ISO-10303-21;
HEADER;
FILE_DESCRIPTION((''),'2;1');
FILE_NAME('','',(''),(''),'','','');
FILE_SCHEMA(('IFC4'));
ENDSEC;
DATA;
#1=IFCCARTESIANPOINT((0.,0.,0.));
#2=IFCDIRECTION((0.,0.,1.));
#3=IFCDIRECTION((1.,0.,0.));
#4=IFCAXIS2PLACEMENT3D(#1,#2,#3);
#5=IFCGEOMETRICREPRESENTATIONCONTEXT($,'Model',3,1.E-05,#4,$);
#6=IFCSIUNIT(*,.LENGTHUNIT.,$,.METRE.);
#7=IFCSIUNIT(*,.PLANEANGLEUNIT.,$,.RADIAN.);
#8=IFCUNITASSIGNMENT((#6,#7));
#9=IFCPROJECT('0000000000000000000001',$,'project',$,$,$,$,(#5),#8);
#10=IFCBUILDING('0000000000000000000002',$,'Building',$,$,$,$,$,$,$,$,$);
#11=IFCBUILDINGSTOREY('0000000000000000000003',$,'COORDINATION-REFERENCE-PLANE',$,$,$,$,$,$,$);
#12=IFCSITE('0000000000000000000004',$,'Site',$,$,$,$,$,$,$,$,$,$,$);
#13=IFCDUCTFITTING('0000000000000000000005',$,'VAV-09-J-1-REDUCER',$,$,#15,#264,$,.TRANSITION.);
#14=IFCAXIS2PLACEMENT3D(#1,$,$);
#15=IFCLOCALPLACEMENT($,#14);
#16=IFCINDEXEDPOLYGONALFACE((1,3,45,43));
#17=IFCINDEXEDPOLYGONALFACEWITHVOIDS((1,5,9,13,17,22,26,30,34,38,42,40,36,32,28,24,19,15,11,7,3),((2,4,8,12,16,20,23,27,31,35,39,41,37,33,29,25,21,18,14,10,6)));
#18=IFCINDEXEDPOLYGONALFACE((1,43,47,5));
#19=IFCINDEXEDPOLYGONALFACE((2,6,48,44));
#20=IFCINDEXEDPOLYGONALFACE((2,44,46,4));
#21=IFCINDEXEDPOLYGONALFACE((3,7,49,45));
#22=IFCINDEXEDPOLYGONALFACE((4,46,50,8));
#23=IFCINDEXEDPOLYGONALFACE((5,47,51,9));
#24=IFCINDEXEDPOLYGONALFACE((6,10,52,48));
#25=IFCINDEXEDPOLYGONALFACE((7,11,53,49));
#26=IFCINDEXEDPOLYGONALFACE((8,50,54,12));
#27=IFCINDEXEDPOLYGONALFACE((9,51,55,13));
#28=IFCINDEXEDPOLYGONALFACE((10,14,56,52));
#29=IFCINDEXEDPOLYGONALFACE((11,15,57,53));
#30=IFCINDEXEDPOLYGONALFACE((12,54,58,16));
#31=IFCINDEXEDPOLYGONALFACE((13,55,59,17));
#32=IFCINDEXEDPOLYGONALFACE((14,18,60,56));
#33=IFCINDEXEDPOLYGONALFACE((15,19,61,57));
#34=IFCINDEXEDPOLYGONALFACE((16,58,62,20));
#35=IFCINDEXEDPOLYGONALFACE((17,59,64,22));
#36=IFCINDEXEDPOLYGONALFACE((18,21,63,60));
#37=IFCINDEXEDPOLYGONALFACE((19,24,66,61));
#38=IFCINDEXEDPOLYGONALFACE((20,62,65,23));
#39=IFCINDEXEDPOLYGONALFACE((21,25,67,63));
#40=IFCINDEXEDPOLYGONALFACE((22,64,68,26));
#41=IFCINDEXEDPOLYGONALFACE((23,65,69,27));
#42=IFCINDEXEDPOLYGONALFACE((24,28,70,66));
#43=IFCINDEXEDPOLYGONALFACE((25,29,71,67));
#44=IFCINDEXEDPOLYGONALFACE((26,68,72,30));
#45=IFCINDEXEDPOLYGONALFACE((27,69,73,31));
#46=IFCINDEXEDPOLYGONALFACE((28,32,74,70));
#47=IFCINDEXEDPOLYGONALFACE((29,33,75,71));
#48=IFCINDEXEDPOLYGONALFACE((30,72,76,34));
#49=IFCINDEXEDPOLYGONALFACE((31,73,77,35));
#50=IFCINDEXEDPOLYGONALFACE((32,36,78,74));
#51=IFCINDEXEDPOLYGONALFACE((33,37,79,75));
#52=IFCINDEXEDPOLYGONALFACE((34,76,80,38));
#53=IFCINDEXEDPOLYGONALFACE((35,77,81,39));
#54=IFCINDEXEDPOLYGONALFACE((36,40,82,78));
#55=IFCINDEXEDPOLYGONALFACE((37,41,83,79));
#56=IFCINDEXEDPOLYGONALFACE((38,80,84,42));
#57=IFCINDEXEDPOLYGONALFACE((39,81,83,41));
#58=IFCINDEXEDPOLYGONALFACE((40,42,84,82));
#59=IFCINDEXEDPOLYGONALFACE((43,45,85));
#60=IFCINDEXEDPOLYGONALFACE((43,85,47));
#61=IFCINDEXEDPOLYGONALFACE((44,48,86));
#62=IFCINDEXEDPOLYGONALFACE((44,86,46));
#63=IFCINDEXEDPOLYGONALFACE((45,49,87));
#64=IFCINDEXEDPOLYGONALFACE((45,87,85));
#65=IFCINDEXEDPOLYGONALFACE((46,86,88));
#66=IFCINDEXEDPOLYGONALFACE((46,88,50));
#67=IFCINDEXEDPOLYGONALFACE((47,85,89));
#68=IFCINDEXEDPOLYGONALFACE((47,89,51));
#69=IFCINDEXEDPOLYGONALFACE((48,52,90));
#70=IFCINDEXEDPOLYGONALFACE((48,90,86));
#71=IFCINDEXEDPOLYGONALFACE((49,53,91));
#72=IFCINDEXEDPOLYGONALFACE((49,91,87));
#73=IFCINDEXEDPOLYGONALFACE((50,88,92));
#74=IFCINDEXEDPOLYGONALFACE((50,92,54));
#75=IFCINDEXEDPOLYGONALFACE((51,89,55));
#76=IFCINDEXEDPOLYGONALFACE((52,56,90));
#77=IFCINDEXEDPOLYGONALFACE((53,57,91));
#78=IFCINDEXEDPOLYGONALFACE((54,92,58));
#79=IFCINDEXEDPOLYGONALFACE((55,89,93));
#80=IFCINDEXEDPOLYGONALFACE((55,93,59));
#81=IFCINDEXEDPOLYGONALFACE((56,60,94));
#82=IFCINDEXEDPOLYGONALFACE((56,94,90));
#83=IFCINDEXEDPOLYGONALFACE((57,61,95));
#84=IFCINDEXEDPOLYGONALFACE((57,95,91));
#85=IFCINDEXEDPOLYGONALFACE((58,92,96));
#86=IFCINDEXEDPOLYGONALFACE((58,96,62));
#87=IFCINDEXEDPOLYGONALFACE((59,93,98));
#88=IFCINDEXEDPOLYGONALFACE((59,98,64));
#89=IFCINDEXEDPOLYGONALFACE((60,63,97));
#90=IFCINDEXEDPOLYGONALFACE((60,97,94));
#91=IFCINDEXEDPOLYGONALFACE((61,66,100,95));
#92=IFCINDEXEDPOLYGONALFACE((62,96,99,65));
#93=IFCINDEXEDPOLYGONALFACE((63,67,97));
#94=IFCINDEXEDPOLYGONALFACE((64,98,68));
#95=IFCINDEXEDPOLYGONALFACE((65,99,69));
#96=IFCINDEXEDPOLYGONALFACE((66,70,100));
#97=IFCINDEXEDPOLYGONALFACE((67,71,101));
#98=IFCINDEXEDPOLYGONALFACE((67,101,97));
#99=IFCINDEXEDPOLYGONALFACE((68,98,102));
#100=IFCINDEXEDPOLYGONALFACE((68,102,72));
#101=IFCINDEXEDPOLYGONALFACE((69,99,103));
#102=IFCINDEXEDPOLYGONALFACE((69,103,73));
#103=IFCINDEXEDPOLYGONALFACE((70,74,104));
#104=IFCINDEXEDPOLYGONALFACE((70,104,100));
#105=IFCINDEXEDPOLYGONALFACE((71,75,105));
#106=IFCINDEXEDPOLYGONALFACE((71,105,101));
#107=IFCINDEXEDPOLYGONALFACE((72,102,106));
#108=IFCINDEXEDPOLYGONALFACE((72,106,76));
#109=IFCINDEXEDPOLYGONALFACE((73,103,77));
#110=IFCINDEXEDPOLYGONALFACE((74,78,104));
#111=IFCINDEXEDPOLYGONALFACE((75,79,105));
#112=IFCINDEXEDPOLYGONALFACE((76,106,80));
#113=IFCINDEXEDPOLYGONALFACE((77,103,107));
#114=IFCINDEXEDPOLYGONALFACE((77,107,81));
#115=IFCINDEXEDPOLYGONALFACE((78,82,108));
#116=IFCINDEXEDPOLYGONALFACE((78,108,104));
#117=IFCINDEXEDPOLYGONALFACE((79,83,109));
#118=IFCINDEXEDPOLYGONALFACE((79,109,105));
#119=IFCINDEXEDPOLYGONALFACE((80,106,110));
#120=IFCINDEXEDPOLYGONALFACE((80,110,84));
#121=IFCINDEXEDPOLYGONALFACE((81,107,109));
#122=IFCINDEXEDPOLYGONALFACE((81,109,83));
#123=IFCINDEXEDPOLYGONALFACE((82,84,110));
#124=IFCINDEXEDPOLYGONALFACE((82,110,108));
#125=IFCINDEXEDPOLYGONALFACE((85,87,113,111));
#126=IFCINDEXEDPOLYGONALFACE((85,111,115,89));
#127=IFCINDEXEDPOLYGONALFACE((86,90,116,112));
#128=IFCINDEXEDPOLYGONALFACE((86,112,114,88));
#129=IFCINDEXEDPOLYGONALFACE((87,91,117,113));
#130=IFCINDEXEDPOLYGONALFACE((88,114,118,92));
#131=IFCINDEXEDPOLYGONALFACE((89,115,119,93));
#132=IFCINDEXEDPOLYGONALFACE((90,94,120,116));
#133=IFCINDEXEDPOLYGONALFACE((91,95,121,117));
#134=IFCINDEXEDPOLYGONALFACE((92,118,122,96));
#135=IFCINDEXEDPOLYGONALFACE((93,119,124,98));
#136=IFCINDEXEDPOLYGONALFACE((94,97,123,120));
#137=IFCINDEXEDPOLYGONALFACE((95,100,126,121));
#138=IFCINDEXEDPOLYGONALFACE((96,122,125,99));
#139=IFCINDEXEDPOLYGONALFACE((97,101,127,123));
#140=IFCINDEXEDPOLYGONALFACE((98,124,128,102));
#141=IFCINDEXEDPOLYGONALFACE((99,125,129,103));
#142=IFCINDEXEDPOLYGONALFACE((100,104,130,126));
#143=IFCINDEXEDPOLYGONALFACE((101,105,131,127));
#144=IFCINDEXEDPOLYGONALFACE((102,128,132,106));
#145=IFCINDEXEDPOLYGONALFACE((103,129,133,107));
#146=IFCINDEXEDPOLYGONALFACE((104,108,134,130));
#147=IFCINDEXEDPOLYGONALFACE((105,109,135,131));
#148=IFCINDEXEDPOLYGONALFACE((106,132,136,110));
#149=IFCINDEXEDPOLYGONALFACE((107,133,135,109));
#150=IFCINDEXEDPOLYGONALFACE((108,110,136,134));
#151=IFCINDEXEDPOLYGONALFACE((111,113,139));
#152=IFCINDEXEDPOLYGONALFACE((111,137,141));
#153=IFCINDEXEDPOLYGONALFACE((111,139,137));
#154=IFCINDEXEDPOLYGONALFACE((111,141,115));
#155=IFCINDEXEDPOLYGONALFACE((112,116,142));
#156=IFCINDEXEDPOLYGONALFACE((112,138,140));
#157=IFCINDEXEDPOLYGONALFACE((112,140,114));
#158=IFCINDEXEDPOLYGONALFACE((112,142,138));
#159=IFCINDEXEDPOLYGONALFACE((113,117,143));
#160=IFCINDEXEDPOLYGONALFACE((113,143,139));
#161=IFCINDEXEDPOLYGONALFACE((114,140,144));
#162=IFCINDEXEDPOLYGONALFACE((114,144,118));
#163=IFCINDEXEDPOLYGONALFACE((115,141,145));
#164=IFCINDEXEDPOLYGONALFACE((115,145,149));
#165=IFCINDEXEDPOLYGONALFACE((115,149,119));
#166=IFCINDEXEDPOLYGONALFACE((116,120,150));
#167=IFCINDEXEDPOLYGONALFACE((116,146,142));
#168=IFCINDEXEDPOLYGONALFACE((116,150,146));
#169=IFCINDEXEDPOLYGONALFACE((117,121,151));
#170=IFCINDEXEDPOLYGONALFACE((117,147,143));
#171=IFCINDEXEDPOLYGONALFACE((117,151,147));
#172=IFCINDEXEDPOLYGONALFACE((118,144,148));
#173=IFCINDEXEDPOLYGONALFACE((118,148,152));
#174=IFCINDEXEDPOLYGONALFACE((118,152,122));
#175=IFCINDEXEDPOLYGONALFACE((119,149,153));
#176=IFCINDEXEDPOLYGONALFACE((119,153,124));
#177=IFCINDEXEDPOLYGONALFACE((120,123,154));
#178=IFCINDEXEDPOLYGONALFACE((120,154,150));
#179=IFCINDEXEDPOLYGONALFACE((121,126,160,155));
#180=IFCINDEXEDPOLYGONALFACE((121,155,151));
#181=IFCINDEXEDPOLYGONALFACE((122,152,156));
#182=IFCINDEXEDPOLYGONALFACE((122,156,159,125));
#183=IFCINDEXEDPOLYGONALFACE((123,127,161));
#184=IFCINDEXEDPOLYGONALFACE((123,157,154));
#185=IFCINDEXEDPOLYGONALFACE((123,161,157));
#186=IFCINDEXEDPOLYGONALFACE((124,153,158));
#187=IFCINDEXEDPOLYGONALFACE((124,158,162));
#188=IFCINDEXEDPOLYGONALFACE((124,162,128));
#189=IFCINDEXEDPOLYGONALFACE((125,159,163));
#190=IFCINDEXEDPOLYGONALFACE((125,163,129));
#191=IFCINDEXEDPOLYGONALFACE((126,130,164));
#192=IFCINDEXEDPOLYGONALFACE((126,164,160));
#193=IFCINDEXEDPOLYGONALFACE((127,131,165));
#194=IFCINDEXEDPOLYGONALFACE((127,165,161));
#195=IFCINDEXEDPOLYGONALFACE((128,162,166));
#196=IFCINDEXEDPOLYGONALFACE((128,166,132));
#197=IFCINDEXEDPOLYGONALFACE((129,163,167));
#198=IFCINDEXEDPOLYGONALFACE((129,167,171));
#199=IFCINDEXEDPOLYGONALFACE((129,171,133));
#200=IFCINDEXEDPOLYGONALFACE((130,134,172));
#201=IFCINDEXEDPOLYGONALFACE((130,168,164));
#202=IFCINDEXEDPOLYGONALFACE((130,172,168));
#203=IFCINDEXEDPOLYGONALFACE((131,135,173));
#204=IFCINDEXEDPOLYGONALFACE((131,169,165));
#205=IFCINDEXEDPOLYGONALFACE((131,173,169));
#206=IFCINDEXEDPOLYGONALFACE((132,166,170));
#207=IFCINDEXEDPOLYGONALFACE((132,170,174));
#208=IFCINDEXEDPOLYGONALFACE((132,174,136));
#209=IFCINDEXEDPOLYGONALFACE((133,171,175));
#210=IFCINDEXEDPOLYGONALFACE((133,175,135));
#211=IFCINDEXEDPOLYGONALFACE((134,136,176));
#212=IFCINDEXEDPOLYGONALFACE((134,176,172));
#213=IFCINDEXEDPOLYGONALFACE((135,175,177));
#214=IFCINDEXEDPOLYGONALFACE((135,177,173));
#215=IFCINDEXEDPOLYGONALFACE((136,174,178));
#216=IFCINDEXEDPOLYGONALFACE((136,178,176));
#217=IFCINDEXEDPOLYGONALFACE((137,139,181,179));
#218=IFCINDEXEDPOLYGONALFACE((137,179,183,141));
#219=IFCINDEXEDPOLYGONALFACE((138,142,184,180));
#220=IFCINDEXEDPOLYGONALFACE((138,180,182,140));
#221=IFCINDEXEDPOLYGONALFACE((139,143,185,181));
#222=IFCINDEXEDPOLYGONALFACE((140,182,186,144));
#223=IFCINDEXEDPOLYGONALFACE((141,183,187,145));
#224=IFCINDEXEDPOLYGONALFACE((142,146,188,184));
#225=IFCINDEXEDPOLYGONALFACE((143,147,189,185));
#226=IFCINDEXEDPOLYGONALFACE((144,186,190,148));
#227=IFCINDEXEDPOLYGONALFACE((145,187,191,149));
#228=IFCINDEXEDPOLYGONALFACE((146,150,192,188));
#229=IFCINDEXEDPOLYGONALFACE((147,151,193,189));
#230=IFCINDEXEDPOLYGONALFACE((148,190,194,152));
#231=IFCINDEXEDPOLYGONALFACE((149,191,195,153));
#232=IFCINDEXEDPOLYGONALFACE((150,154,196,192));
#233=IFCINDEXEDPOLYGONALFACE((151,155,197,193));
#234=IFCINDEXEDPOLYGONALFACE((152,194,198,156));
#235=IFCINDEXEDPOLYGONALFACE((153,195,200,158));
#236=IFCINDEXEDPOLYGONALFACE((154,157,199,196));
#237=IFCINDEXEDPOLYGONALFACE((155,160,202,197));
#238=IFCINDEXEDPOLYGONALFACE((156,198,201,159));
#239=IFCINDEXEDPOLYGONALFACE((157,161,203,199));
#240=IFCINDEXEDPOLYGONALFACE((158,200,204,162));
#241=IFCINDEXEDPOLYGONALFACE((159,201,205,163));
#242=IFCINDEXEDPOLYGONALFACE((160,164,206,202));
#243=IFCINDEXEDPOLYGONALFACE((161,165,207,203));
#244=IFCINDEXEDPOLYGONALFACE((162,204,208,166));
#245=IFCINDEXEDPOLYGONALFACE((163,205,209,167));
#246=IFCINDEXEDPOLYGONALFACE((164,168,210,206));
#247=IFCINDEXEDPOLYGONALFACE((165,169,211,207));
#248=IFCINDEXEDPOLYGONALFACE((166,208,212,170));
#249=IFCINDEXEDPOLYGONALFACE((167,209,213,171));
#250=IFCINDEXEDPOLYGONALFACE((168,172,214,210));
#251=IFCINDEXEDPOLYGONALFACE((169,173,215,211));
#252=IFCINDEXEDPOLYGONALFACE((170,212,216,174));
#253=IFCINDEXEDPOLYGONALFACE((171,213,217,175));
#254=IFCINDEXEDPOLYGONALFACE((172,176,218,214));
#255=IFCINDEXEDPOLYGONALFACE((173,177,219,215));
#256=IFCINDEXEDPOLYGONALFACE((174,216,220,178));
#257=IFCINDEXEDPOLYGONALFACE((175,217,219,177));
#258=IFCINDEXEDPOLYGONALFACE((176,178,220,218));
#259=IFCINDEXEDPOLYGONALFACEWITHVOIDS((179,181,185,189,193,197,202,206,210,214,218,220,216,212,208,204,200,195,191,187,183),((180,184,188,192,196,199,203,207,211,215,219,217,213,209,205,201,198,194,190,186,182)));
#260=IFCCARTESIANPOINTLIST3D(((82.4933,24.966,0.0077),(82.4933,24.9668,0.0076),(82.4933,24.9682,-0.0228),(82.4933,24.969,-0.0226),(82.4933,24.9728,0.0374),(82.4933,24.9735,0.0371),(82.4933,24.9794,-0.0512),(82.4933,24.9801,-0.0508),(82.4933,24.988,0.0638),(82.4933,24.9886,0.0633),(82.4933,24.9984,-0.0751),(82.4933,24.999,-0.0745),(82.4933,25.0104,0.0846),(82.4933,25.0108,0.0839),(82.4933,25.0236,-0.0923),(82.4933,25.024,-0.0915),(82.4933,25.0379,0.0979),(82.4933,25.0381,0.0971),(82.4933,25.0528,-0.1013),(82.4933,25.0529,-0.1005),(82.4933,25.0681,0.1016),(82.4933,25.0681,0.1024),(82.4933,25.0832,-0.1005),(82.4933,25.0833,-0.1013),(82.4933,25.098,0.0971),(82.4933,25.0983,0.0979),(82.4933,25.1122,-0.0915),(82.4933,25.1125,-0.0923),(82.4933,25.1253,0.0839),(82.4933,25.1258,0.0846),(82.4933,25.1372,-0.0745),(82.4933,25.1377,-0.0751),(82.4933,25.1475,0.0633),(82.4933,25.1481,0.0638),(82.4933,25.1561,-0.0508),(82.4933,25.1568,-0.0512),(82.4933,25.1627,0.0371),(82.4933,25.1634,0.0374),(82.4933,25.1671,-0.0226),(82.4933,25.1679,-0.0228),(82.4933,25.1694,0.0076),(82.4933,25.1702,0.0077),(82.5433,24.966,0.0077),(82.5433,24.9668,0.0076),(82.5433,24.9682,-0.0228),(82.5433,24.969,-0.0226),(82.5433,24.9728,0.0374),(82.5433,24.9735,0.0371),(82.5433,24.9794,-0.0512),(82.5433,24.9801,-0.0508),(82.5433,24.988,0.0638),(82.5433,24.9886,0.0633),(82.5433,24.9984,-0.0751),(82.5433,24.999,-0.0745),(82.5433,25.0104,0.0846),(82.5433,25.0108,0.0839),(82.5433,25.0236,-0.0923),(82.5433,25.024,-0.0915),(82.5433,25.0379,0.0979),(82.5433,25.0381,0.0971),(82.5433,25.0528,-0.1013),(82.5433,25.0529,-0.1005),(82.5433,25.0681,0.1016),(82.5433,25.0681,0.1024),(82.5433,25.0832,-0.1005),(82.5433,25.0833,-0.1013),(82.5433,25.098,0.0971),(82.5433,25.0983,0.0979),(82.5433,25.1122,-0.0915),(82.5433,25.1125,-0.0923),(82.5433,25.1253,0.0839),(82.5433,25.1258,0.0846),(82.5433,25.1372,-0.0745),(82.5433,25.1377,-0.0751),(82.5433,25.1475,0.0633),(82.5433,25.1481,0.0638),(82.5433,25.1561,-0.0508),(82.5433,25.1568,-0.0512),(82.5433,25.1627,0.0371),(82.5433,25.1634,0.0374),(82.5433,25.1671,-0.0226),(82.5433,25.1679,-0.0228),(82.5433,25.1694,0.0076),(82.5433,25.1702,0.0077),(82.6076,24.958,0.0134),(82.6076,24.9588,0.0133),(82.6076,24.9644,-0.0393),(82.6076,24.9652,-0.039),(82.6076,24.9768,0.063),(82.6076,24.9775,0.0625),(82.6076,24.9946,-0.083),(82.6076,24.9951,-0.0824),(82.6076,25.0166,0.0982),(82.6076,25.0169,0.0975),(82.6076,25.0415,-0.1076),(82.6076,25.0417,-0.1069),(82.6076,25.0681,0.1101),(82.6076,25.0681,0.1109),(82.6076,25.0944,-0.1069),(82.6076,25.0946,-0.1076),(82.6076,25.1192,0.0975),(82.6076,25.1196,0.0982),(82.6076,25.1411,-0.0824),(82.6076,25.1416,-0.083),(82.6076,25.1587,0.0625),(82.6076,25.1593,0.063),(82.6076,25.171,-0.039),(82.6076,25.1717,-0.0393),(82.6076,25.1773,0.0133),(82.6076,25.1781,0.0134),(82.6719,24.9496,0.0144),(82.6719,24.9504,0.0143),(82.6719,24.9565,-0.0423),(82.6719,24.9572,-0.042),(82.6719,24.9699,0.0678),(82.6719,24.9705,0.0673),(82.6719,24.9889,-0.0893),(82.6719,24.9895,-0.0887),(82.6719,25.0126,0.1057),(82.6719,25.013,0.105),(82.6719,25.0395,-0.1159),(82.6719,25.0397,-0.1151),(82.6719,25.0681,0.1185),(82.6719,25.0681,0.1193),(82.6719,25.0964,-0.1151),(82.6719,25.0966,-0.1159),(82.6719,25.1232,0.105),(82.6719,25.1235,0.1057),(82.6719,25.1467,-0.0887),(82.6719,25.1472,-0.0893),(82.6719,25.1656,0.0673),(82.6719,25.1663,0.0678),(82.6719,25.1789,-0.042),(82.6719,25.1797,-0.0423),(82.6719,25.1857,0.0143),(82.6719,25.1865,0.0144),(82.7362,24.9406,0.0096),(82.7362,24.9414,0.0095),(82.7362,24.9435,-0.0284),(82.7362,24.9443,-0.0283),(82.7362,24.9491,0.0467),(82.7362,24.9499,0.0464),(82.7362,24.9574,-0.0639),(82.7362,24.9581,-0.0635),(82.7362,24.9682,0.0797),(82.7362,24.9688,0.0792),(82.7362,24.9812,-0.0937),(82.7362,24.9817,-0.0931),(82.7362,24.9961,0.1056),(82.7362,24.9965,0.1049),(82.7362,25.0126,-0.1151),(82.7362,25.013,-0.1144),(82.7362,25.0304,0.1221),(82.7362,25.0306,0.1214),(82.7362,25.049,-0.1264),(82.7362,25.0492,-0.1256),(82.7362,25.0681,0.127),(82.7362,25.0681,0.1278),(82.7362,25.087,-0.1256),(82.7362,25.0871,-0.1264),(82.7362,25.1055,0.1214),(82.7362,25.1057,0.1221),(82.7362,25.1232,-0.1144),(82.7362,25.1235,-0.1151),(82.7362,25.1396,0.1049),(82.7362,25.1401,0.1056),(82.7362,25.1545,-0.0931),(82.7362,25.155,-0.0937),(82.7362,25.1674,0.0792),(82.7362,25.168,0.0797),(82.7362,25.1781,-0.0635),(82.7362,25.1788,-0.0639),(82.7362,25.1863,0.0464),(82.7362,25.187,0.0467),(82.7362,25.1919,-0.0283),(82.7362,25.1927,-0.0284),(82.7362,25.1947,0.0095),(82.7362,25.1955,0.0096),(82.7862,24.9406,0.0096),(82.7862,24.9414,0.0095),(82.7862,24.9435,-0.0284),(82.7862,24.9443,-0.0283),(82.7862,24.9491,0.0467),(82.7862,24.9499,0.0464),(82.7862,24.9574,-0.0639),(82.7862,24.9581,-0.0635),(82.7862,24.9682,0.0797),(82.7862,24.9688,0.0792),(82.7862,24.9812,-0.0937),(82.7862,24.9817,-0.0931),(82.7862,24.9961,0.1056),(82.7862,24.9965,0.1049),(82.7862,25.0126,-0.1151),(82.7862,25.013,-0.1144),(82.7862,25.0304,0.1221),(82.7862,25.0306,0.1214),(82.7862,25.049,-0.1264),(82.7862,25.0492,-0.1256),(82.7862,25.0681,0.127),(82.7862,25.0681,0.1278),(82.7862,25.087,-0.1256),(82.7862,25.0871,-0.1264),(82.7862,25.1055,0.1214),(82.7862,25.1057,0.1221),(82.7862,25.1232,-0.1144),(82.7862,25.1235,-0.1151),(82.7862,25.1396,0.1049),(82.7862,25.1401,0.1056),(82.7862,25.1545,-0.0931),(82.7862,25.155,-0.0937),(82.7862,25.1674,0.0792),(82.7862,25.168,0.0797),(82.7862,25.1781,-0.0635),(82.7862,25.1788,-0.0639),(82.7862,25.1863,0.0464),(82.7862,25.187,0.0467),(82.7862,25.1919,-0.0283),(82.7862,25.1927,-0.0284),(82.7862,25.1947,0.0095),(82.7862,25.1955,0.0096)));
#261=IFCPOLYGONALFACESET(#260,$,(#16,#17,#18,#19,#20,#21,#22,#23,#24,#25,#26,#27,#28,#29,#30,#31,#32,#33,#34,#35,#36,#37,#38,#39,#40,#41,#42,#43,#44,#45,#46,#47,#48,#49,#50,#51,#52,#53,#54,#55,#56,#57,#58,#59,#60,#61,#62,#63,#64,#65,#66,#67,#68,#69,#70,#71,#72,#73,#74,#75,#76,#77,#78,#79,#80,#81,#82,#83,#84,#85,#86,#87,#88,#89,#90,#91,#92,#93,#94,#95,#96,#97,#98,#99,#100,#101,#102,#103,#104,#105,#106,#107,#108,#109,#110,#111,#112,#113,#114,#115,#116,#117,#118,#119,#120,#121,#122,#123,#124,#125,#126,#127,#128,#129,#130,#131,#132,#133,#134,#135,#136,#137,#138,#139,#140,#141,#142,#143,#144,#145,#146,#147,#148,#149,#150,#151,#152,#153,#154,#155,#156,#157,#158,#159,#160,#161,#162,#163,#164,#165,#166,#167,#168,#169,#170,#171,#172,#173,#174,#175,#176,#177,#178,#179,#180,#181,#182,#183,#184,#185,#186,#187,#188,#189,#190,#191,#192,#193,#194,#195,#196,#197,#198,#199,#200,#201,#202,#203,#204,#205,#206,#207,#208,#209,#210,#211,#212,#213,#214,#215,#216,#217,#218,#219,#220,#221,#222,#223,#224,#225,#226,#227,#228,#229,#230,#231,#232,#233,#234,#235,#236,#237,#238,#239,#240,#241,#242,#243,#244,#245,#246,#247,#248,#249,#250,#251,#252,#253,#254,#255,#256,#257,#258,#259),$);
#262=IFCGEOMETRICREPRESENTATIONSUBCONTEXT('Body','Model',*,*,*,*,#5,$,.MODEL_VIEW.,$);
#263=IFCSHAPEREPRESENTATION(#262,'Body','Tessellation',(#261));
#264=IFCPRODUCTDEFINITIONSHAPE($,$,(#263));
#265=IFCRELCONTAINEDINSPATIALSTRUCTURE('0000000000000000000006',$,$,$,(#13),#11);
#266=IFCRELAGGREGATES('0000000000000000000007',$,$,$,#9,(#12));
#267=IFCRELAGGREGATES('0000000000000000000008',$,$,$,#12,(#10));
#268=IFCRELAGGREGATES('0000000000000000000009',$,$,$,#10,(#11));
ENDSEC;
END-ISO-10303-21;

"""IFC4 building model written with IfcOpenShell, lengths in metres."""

from ifc_helpers import new_model, entity, si_unit, frame, origin_with_axes, place, context, subcontext, project, spatial, element, save


model = new_model("IFC4")

# Units and contexts
model_context = context("Model", 3, precision=1e-05, world=origin_with_axes())
body_context_1 = subcontext(model_context, "Body", "Model", "MODEL_VIEW")
ifc_project = project(units=[si_unit("LENGTHUNIT", "METRE"), si_unit("PLANEANGLEUNIT", "RADIAN")], contexts=[model_context])

# Site, building, storey
site = spatial("IfcSite", under=ifc_project, Name="Site")
building = spatial("IfcBuilding", under=site, Name="Building")
storey = spatial("IfcBuildingStorey", under=building, Name="COORDINATION-REFERENCE-PLANE")

# Duct fitting
for number, where, z_axis, x_axis, name in (
    (1, (82.7862, 25.0681, 0.0), (0.0, -1.0, 0.0), (0.0, 0.0, 1.0), "VAV-09-J-1-REDUCER"),
):
    element("IfcDuctFitting", number, at=place(None, frame(where, z_axis=z_axis, x_axis=x_axis)), inside=storey, Name=name, PredefinedType="TRANSITION", context=body_context_1, shape_type="SweptSolid", body=[
        entity("IfcRevolvedAreaSolid", entity("IfcArbitraryClosedProfileDef", "AREA", None, entity("IfcPolyline", [entity("IfcCartesianPoint", [0.1278, 0.0]), entity("IfcCartesianPoint", [0.1278, 0.05]), entity("IfcCartesianPoint", [0.1024, 0.2429]), entity("IfcCartesianPoint", [0.1024, 0.2929]), entity("IfcCartesianPoint", [0.1016, 0.2929]), entity("IfcCartesianPoint", [0.1016, 0.2429]), entity("IfcCartesianPoint", [0.127, 0.05]), entity("IfcCartesianPoint", [0.127, 0.0]), entity("IfcCartesianPoint", [0.1278, 0.0])])), entity("IfcAxis2Placement3D", entity("IfcCartesianPoint", [0.0, 0.0, 0.0])), entity("IfcAxis1Placement", entity("IfcCartesianPoint", [0.0, 0.0, 0.0]), entity("IfcDirection", [0.0, 1.0, 0.0])), 6.283185),
    ])

save(model, "model.ifc")
